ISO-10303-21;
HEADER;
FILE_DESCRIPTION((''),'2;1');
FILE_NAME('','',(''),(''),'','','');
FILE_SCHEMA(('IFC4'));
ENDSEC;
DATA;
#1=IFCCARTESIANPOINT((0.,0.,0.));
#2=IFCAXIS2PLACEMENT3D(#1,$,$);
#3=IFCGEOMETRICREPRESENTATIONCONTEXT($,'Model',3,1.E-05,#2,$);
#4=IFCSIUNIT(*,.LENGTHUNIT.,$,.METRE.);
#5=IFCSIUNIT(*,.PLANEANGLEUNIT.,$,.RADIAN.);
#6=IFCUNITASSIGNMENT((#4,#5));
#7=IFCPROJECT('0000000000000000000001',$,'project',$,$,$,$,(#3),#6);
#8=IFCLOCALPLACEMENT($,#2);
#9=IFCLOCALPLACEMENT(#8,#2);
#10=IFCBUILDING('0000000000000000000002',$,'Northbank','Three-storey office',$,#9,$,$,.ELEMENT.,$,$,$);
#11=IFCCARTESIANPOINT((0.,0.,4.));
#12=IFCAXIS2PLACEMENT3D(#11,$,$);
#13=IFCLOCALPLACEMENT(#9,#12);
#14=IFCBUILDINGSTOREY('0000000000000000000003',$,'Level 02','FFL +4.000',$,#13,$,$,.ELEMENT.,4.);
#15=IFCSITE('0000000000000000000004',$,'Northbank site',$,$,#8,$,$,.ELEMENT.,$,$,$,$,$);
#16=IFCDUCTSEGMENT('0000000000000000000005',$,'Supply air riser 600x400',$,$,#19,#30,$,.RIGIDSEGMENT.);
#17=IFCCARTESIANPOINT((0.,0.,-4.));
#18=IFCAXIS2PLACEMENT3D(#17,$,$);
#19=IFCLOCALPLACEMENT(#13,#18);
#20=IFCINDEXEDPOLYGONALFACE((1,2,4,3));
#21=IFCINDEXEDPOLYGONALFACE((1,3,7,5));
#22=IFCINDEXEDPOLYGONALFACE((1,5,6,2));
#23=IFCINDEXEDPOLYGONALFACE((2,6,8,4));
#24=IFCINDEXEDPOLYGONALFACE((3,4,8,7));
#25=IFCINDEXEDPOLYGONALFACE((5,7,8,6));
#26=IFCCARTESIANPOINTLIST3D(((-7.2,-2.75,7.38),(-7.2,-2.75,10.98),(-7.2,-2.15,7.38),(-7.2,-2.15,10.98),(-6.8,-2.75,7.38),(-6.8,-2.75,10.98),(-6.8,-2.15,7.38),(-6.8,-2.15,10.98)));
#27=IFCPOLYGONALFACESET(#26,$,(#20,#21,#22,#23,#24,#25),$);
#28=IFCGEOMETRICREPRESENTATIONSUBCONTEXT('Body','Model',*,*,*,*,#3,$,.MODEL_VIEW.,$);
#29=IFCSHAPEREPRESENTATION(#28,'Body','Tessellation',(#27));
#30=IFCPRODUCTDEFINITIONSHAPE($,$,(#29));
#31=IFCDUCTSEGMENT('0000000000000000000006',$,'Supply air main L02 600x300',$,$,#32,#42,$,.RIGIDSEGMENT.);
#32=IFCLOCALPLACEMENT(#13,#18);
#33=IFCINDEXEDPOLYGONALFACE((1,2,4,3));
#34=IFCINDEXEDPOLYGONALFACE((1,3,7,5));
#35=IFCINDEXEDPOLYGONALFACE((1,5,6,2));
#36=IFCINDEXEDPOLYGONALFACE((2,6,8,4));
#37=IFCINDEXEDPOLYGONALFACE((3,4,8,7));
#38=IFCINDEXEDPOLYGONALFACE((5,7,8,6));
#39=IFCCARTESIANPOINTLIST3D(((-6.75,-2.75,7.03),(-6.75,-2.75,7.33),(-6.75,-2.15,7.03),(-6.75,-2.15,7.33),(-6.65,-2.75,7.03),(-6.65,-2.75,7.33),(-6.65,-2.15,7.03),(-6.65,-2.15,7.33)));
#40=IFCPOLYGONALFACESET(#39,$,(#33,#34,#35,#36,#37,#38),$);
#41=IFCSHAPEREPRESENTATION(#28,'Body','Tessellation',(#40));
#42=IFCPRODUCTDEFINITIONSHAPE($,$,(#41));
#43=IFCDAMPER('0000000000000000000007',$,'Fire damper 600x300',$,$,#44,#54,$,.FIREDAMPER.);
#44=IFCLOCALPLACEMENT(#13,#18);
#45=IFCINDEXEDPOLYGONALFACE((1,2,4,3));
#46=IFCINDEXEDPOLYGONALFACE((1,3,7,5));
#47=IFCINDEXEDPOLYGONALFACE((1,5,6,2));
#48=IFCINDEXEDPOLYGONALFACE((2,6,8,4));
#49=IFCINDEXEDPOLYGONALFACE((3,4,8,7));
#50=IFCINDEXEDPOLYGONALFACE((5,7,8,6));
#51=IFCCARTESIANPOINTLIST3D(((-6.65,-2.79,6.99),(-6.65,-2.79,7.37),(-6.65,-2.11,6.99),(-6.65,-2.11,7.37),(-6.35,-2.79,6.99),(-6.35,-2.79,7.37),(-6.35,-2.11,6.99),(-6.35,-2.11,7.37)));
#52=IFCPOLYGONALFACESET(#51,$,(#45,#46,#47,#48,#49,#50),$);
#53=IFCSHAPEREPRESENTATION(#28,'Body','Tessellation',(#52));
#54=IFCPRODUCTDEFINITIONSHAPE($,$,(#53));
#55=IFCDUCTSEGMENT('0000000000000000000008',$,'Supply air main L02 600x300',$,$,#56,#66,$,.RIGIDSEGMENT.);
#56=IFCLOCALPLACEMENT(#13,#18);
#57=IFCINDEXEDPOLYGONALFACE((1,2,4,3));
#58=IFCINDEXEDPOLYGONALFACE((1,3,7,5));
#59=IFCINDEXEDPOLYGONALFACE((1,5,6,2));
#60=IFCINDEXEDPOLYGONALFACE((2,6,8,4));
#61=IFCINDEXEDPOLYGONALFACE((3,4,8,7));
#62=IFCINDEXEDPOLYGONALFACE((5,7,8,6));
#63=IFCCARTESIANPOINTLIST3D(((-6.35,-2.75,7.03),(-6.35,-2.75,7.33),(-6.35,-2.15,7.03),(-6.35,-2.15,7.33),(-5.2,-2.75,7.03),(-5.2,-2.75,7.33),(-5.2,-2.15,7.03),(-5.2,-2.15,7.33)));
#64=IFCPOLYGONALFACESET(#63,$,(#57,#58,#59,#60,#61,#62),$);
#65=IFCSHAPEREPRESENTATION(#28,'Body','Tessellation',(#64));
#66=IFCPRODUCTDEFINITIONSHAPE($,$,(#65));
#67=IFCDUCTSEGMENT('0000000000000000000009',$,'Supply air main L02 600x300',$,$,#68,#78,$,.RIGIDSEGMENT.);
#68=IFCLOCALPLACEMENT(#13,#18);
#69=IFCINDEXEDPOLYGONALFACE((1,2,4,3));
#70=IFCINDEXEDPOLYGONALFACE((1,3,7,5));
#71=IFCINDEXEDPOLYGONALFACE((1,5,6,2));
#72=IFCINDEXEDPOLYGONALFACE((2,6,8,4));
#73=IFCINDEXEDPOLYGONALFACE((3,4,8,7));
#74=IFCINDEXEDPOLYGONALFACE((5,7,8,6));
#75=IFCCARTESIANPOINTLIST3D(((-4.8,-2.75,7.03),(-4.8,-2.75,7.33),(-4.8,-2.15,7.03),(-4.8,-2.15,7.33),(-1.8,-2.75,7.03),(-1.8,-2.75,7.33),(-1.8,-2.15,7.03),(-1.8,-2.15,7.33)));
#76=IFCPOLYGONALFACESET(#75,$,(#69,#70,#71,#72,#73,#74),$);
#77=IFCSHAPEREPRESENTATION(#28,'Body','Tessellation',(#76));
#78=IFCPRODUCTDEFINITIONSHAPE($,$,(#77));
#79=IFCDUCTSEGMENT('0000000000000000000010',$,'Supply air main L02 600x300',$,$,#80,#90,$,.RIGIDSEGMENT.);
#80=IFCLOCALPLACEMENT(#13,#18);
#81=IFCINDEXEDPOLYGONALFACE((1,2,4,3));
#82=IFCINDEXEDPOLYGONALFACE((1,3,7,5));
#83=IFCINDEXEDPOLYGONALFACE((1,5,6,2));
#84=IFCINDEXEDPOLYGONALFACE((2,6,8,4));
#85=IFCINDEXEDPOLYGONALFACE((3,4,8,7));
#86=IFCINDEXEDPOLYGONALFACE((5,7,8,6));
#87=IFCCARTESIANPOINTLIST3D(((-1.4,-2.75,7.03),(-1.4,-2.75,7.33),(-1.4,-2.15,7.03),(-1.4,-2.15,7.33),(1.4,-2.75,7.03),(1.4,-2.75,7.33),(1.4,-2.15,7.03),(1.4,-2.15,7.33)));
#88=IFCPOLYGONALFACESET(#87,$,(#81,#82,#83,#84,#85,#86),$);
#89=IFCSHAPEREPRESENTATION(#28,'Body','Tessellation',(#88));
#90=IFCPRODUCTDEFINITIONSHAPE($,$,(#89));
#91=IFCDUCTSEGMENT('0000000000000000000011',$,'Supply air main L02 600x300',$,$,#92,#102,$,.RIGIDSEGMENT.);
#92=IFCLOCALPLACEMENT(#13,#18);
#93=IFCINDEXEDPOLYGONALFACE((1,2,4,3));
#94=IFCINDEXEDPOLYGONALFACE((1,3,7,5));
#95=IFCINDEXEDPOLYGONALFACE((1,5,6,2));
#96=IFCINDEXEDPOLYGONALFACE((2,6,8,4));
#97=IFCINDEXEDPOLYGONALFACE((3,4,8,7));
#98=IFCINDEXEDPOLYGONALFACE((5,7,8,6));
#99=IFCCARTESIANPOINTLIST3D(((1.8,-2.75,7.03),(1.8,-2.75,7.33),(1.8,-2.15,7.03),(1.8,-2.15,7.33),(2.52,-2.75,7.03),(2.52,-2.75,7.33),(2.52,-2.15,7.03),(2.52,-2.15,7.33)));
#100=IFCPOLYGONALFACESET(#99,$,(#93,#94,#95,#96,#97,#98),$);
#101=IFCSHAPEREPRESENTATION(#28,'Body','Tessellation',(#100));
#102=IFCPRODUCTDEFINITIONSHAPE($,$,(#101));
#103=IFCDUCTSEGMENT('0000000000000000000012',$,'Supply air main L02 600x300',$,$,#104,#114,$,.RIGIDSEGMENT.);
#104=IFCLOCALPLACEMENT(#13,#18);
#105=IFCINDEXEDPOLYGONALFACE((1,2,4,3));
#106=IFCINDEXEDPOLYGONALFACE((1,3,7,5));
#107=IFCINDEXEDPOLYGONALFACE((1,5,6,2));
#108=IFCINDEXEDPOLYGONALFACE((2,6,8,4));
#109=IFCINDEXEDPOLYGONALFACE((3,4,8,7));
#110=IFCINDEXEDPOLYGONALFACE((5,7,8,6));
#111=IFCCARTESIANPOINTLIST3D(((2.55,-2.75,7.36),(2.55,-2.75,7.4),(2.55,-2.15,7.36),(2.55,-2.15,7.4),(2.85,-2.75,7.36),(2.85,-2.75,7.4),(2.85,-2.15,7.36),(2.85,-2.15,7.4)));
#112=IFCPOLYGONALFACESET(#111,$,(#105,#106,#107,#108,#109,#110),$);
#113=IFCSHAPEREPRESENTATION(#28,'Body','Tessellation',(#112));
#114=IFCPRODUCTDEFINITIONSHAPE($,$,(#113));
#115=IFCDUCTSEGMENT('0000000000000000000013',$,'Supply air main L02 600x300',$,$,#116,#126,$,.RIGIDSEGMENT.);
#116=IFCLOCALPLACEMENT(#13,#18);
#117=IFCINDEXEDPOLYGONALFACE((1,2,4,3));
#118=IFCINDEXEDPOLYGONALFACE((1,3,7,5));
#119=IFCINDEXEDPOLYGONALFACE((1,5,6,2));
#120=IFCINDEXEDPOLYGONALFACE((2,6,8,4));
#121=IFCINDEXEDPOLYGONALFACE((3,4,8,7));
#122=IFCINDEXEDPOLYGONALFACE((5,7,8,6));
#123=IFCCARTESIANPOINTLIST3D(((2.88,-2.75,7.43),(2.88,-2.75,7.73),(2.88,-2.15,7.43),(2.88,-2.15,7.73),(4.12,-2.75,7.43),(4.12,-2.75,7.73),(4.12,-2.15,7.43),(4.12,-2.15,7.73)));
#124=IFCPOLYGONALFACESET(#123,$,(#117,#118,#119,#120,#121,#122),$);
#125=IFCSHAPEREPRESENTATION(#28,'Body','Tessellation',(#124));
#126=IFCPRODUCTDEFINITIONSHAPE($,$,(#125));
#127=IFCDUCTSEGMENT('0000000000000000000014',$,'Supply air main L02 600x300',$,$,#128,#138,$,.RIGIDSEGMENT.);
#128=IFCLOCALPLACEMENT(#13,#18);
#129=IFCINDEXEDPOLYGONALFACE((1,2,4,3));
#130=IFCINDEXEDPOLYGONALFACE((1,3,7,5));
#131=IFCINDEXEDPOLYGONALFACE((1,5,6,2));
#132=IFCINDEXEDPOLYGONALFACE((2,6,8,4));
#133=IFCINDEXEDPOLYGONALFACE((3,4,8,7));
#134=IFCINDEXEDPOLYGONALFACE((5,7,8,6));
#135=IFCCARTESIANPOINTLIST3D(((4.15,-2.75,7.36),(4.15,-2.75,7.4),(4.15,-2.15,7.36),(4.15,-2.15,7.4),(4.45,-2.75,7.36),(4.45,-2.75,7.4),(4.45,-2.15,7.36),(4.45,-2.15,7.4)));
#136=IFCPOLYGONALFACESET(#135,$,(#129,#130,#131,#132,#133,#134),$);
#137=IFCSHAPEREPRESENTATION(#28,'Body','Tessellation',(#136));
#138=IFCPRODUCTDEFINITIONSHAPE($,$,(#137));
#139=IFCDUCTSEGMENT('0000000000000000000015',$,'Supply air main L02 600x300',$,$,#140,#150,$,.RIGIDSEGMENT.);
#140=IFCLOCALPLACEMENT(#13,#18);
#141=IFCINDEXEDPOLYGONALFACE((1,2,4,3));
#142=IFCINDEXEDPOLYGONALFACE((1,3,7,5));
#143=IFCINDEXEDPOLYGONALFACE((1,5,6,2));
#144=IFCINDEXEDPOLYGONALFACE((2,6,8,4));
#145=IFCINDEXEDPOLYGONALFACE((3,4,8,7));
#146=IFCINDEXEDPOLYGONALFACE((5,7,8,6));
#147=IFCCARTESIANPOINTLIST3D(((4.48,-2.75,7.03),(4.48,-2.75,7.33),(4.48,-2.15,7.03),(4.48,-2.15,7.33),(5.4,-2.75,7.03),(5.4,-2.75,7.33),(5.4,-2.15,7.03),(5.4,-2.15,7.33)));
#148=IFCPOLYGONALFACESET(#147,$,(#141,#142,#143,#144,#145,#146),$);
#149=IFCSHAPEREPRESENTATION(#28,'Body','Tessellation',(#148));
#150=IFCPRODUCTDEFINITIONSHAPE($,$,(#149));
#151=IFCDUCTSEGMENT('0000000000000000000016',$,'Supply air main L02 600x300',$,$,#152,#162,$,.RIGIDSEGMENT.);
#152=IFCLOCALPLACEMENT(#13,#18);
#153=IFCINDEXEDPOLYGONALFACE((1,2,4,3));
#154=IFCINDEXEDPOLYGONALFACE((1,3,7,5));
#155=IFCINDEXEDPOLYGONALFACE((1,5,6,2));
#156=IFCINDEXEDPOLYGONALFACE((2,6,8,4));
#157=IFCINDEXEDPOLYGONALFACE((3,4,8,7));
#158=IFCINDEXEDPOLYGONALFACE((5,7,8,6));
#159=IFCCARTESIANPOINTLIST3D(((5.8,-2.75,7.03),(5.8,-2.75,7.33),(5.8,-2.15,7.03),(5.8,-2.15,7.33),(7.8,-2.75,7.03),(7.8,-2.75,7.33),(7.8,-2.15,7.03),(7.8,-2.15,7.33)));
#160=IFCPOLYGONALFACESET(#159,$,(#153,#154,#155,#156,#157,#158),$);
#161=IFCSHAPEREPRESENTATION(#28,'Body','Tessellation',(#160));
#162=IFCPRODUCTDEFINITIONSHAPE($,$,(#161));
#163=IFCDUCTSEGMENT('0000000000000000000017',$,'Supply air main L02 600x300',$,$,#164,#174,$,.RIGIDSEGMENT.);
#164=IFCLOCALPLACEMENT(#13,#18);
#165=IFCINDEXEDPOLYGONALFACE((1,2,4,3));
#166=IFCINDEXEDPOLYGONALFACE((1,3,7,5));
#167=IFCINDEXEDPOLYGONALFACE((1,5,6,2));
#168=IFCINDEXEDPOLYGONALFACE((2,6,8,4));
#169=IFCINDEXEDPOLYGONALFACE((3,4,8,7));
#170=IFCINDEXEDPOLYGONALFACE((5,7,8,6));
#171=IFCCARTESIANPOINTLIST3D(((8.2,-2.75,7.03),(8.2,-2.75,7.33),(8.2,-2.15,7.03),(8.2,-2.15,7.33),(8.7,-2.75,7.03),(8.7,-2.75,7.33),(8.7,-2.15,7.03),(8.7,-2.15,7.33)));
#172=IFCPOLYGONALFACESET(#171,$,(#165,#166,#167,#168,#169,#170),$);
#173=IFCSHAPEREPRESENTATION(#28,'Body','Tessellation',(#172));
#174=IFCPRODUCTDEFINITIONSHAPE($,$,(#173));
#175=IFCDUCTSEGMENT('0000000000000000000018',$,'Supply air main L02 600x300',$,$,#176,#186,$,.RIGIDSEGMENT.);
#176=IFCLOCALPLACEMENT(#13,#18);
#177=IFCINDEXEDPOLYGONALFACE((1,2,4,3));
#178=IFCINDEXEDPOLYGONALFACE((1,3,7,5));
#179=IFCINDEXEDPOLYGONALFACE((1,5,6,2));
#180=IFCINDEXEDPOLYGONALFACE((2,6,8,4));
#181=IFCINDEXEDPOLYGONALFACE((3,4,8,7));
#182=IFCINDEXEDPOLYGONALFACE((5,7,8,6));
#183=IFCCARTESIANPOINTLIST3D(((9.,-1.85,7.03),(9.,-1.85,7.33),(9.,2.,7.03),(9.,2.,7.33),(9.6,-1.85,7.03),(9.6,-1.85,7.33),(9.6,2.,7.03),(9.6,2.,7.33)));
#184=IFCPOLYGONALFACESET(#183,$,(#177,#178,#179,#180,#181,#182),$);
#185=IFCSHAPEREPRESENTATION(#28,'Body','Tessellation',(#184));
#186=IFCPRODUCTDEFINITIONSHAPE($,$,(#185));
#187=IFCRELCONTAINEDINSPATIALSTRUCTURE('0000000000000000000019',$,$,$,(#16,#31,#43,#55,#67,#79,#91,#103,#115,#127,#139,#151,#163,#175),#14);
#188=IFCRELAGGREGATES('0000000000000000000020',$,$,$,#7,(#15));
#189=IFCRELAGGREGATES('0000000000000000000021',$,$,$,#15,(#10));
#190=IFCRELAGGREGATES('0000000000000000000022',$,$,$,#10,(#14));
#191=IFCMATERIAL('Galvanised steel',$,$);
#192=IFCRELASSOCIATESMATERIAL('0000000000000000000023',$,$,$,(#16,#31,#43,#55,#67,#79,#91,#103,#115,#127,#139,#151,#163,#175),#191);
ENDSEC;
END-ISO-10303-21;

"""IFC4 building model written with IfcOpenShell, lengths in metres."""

from ifc_helpers import new_model, si_unit, frame, origin, place, context, subcontext, project, spatial, rectangle, extrude, material, element, save


model = new_model("IFC4")

# Units and contexts
model_context = context("Model", 3, precision=1e-05, world=origin())
body_context = subcontext(model_context, "Body", "Model", "MODEL_VIEW")
ifc_project = project(units=[si_unit("LENGTHUNIT", "METRE"), si_unit("PLANEANGLEUNIT", "RADIAN")], contexts=[model_context])

# Site, building, storey
site_placement = place(None, origin())
site = spatial("IfcSite", under=ifc_project, at=site_placement, Name="Northbank site", CompositionType="ELEMENT")
building_placement = place(site_placement, origin())
building = spatial("IfcBuilding", under=site, at=building_placement, Name="Northbank", Description="Three-storey office", CompositionType="ELEMENT")
storey_placement = place(building_placement, frame((0.0, 0.0, 4.0)))
storey = spatial("IfcBuildingStorey", under=building, at=storey_placement, Name="Level 02", Description="FFL +4.000", CompositionType="ELEMENT", Elevation=4.0)

# Shared definitions
ifc_material = material(Name="Galvanised steel")

# Duct segments
duct_segment_1_placement = place(storey_placement, frame((0.0, 0.0, -4.0)))
element("IfcDuctSegment", 1, at=duct_segment_1_placement, inside=storey, material=ifc_material, Name="Supply air riser 600x400", PredefinedType="RIGIDSEGMENT", context=body_context, shape_type="SweptSolid", body=[
    extrude(rectangle(XDim=0.6, YDim=0.4), frame((-7.0, -2.45, 10.98), z_axis=(0.0, 0.0, -1.0), x_axis=(0.0, -1.0, 0.0)), (0.0, 0.0, 1.0), 3.6),
])
duct_segment_2_placement = place(storey_placement, frame((0.0, 0.0, -4.0)))
element("IfcDuctSegment", 2, at=duct_segment_2_placement, inside=storey, material=ifc_material, Name="Supply air main L02 600x300", PredefinedType="RIGIDSEGMENT", context=body_context, shape_type="SweptSolid", body=[
    extrude(rectangle(XDim=0.6, YDim=0.3), frame((-6.75, -2.45, 7.18), z_axis=(1.0, 0.0, 0.0), x_axis=(0.0, 1.0, 0.0)), (0.0, 0.0, 1.0), 0.1),
])

# Damper
damper_placement = place(storey_placement, frame((0.0, 0.0, -4.0)))
element("IfcDamper", 3, at=damper_placement, inside=storey, material=ifc_material, Name="Fire damper 600x300", PredefinedType="FIREDAMPER", context=body_context, shape_type="SweptSolid", body=[
    extrude(rectangle(XDim=0.68, YDim=0.38), frame((-6.65, -2.45, 7.18), z_axis=(1.0, 0.0, 0.0), x_axis=(0.0, 1.0, 0.0)), (0.0, 0.0, 1.0), 0.3),
])

# Duct segment
duct_segment_3_placement = place(storey_placement, frame((0.0, 0.0, -4.0)))
element("IfcDuctSegment", 4, at=duct_segment_3_placement, inside=storey, material=ifc_material, Name="Supply air main L02 600x300", PredefinedType="RIGIDSEGMENT", context=body_context, shape_type="SweptSolid", body=[
    extrude(rectangle(XDim=0.6, YDim=0.3), frame((-6.35, -2.45, 7.18), z_axis=(1.0, 0.0, 0.0), x_axis=(0.0, 1.0, 0.0)), (0.0, 0.0, 1.0), 1.15),
])

# Duct segment
duct_segment_4_placement = place(storey_placement, frame((0.0, 0.0, -4.0)))
element("IfcDuctSegment", 5, at=duct_segment_4_placement, inside=storey, material=ifc_material, Name="Supply air main L02 600x300", PredefinedType="RIGIDSEGMENT", context=body_context, shape_type="SweptSolid", body=[
    extrude(rectangle(XDim=0.6, YDim=0.3), frame((-4.8, -2.45, 7.18), z_axis=(1.0, 0.0, 0.0), x_axis=(0.0, 1.0, 0.0)), (0.0, 0.0, 1.0), 3.0),
])

# Duct segments
duct_segment_5_placement = place(storey_placement, frame((0.0, 0.0, -4.0)))
element("IfcDuctSegment", 6, at=duct_segment_5_placement, inside=storey, material=ifc_material, Name="Supply air main L02 600x300", PredefinedType="RIGIDSEGMENT", context=body_context, shape_type="SweptSolid", body=[
    extrude(rectangle(XDim=0.6, YDim=0.3), frame((-1.4, -2.45, 7.18), z_axis=(1.0, 0.0, 0.0), x_axis=(0.0, 1.0, 0.0)), (0.0, 0.0, 1.0), 2.8),
])
duct_segment_6_placement = place(storey_placement, frame((0.0, 0.0, -4.0)))
element("IfcDuctSegment", 7, at=duct_segment_6_placement, inside=storey, material=ifc_material, Name="Supply air main L02 600x300", PredefinedType="RIGIDSEGMENT", context=body_context, shape_type="SweptSolid", body=[
    extrude(rectangle(XDim=0.6, YDim=0.3), frame((1.8, -2.45, 7.18), z_axis=(1.0, 0.0, 0.0), x_axis=(0.0, 1.0, 0.0)), (0.0, 0.0, 1.0), 0.72),
])
duct_segment_7_placement = place(storey_placement, frame((0.0, 0.0, -4.0)))
element("IfcDuctSegment", 8, at=duct_segment_7_placement, inside=storey, material=ifc_material, Name="Supply air main L02 600x300", PredefinedType="RIGIDSEGMENT", context=body_context, shape_type="SweptSolid", body=[
    extrude(rectangle(XDim=0.6, YDim=0.3), frame((2.7, -2.45, 7.36), z_axis=(0.0, 0.0, 1.0), x_axis=(0.0, 1.0, 0.0)), (0.0, 0.0, 1.0), 0.04),
])
duct_segment_8_placement = place(storey_placement, frame((0.0, 0.0, -4.0)))
element("IfcDuctSegment", 9, at=duct_segment_8_placement, inside=storey, material=ifc_material, Name="Supply air main L02 600x300", PredefinedType="RIGIDSEGMENT", context=body_context, shape_type="SweptSolid", body=[
    extrude(rectangle(XDim=0.6, YDim=0.3), frame((2.88, -2.45, 7.58), z_axis=(1.0, 0.0, 0.0), x_axis=(0.0, 1.0, 0.0)), (0.0, 0.0, 1.0), 1.24),
])
duct_segment_9_placement = place(storey_placement, frame((0.0, 0.0, -4.0)))
element("IfcDuctSegment", 10, at=duct_segment_9_placement, inside=storey, material=ifc_material, Name="Supply air main L02 600x300", PredefinedType="RIGIDSEGMENT", context=body_context, shape_type="SweptSolid", body=[
    extrude(rectangle(XDim=0.6, YDim=0.3), frame((4.3, -2.45, 7.4), z_axis=(0.0, 0.0, -1.0), x_axis=(0.0, 1.0, 0.0)), (0.0, 0.0, 1.0), 0.04),
])

# Duct segment
duct_segment_10_placement = place(storey_placement, frame((0.0, 0.0, -4.0)))
element("IfcDuctSegment", 11, at=duct_segment_10_placement, inside=storey, material=ifc_material, Name="Supply air main L02 600x300", PredefinedType="RIGIDSEGMENT", context=body_context, shape_type="SweptSolid", body=[
    extrude(rectangle(XDim=0.6, YDim=0.3), frame((4.48, -2.45, 7.18), z_axis=(1.0, 0.0, 0.0), x_axis=(0.0, 1.0, 0.0)), (0.0, 0.0, 1.0), 0.92),
])

# Duct segments
duct_segment_11_placement = place(storey_placement, frame((0.0, 0.0, -4.0)))
element("IfcDuctSegment", 12, at=duct_segment_11_placement, inside=storey, material=ifc_material, Name="Supply air main L02 600x300", PredefinedType="RIGIDSEGMENT", context=body_context, shape_type="SweptSolid", body=[
    extrude(rectangle(XDim=0.6, YDim=0.3), frame((5.8, -2.45, 7.18), z_axis=(1.0, 0.0, 0.0), x_axis=(0.0, 1.0, 0.0)), (0.0, 0.0, 1.0), 2.0),
])
duct_segment_12_placement = place(storey_placement, frame((0.0, 0.0, -4.0)))
element("IfcDuctSegment", 13, at=duct_segment_12_placement, inside=storey, material=ifc_material, Name="Supply air main L02 600x300", PredefinedType="RIGIDSEGMENT", context=body_context, shape_type="SweptSolid", body=[
    extrude(rectangle(XDim=0.6, YDim=0.3), frame((8.2, -2.45, 7.18), z_axis=(1.0, 0.0, 0.0), x_axis=(0.0, 1.0, 0.0)), (0.0, 0.0, 1.0), 0.5),
])
duct_segment_13_placement = place(storey_placement, frame((0.0, 0.0, -4.0)))
element("IfcDuctSegment", 14, at=duct_segment_13_placement, inside=storey, material=ifc_material, Name="Supply air main L02 600x300", PredefinedType="RIGIDSEGMENT", context=body_context, shape_type="SweptSolid", body=[
    extrude(rectangle(XDim=0.6, YDim=0.3), frame((9.3, -1.85, 7.18), z_axis=(0.0, 1.0, 0.0), x_axis=(-1.0, 0.0, 0.0)), (0.0, 0.0, 1.0), 3.85),
])

save(model, "model.ifc")
